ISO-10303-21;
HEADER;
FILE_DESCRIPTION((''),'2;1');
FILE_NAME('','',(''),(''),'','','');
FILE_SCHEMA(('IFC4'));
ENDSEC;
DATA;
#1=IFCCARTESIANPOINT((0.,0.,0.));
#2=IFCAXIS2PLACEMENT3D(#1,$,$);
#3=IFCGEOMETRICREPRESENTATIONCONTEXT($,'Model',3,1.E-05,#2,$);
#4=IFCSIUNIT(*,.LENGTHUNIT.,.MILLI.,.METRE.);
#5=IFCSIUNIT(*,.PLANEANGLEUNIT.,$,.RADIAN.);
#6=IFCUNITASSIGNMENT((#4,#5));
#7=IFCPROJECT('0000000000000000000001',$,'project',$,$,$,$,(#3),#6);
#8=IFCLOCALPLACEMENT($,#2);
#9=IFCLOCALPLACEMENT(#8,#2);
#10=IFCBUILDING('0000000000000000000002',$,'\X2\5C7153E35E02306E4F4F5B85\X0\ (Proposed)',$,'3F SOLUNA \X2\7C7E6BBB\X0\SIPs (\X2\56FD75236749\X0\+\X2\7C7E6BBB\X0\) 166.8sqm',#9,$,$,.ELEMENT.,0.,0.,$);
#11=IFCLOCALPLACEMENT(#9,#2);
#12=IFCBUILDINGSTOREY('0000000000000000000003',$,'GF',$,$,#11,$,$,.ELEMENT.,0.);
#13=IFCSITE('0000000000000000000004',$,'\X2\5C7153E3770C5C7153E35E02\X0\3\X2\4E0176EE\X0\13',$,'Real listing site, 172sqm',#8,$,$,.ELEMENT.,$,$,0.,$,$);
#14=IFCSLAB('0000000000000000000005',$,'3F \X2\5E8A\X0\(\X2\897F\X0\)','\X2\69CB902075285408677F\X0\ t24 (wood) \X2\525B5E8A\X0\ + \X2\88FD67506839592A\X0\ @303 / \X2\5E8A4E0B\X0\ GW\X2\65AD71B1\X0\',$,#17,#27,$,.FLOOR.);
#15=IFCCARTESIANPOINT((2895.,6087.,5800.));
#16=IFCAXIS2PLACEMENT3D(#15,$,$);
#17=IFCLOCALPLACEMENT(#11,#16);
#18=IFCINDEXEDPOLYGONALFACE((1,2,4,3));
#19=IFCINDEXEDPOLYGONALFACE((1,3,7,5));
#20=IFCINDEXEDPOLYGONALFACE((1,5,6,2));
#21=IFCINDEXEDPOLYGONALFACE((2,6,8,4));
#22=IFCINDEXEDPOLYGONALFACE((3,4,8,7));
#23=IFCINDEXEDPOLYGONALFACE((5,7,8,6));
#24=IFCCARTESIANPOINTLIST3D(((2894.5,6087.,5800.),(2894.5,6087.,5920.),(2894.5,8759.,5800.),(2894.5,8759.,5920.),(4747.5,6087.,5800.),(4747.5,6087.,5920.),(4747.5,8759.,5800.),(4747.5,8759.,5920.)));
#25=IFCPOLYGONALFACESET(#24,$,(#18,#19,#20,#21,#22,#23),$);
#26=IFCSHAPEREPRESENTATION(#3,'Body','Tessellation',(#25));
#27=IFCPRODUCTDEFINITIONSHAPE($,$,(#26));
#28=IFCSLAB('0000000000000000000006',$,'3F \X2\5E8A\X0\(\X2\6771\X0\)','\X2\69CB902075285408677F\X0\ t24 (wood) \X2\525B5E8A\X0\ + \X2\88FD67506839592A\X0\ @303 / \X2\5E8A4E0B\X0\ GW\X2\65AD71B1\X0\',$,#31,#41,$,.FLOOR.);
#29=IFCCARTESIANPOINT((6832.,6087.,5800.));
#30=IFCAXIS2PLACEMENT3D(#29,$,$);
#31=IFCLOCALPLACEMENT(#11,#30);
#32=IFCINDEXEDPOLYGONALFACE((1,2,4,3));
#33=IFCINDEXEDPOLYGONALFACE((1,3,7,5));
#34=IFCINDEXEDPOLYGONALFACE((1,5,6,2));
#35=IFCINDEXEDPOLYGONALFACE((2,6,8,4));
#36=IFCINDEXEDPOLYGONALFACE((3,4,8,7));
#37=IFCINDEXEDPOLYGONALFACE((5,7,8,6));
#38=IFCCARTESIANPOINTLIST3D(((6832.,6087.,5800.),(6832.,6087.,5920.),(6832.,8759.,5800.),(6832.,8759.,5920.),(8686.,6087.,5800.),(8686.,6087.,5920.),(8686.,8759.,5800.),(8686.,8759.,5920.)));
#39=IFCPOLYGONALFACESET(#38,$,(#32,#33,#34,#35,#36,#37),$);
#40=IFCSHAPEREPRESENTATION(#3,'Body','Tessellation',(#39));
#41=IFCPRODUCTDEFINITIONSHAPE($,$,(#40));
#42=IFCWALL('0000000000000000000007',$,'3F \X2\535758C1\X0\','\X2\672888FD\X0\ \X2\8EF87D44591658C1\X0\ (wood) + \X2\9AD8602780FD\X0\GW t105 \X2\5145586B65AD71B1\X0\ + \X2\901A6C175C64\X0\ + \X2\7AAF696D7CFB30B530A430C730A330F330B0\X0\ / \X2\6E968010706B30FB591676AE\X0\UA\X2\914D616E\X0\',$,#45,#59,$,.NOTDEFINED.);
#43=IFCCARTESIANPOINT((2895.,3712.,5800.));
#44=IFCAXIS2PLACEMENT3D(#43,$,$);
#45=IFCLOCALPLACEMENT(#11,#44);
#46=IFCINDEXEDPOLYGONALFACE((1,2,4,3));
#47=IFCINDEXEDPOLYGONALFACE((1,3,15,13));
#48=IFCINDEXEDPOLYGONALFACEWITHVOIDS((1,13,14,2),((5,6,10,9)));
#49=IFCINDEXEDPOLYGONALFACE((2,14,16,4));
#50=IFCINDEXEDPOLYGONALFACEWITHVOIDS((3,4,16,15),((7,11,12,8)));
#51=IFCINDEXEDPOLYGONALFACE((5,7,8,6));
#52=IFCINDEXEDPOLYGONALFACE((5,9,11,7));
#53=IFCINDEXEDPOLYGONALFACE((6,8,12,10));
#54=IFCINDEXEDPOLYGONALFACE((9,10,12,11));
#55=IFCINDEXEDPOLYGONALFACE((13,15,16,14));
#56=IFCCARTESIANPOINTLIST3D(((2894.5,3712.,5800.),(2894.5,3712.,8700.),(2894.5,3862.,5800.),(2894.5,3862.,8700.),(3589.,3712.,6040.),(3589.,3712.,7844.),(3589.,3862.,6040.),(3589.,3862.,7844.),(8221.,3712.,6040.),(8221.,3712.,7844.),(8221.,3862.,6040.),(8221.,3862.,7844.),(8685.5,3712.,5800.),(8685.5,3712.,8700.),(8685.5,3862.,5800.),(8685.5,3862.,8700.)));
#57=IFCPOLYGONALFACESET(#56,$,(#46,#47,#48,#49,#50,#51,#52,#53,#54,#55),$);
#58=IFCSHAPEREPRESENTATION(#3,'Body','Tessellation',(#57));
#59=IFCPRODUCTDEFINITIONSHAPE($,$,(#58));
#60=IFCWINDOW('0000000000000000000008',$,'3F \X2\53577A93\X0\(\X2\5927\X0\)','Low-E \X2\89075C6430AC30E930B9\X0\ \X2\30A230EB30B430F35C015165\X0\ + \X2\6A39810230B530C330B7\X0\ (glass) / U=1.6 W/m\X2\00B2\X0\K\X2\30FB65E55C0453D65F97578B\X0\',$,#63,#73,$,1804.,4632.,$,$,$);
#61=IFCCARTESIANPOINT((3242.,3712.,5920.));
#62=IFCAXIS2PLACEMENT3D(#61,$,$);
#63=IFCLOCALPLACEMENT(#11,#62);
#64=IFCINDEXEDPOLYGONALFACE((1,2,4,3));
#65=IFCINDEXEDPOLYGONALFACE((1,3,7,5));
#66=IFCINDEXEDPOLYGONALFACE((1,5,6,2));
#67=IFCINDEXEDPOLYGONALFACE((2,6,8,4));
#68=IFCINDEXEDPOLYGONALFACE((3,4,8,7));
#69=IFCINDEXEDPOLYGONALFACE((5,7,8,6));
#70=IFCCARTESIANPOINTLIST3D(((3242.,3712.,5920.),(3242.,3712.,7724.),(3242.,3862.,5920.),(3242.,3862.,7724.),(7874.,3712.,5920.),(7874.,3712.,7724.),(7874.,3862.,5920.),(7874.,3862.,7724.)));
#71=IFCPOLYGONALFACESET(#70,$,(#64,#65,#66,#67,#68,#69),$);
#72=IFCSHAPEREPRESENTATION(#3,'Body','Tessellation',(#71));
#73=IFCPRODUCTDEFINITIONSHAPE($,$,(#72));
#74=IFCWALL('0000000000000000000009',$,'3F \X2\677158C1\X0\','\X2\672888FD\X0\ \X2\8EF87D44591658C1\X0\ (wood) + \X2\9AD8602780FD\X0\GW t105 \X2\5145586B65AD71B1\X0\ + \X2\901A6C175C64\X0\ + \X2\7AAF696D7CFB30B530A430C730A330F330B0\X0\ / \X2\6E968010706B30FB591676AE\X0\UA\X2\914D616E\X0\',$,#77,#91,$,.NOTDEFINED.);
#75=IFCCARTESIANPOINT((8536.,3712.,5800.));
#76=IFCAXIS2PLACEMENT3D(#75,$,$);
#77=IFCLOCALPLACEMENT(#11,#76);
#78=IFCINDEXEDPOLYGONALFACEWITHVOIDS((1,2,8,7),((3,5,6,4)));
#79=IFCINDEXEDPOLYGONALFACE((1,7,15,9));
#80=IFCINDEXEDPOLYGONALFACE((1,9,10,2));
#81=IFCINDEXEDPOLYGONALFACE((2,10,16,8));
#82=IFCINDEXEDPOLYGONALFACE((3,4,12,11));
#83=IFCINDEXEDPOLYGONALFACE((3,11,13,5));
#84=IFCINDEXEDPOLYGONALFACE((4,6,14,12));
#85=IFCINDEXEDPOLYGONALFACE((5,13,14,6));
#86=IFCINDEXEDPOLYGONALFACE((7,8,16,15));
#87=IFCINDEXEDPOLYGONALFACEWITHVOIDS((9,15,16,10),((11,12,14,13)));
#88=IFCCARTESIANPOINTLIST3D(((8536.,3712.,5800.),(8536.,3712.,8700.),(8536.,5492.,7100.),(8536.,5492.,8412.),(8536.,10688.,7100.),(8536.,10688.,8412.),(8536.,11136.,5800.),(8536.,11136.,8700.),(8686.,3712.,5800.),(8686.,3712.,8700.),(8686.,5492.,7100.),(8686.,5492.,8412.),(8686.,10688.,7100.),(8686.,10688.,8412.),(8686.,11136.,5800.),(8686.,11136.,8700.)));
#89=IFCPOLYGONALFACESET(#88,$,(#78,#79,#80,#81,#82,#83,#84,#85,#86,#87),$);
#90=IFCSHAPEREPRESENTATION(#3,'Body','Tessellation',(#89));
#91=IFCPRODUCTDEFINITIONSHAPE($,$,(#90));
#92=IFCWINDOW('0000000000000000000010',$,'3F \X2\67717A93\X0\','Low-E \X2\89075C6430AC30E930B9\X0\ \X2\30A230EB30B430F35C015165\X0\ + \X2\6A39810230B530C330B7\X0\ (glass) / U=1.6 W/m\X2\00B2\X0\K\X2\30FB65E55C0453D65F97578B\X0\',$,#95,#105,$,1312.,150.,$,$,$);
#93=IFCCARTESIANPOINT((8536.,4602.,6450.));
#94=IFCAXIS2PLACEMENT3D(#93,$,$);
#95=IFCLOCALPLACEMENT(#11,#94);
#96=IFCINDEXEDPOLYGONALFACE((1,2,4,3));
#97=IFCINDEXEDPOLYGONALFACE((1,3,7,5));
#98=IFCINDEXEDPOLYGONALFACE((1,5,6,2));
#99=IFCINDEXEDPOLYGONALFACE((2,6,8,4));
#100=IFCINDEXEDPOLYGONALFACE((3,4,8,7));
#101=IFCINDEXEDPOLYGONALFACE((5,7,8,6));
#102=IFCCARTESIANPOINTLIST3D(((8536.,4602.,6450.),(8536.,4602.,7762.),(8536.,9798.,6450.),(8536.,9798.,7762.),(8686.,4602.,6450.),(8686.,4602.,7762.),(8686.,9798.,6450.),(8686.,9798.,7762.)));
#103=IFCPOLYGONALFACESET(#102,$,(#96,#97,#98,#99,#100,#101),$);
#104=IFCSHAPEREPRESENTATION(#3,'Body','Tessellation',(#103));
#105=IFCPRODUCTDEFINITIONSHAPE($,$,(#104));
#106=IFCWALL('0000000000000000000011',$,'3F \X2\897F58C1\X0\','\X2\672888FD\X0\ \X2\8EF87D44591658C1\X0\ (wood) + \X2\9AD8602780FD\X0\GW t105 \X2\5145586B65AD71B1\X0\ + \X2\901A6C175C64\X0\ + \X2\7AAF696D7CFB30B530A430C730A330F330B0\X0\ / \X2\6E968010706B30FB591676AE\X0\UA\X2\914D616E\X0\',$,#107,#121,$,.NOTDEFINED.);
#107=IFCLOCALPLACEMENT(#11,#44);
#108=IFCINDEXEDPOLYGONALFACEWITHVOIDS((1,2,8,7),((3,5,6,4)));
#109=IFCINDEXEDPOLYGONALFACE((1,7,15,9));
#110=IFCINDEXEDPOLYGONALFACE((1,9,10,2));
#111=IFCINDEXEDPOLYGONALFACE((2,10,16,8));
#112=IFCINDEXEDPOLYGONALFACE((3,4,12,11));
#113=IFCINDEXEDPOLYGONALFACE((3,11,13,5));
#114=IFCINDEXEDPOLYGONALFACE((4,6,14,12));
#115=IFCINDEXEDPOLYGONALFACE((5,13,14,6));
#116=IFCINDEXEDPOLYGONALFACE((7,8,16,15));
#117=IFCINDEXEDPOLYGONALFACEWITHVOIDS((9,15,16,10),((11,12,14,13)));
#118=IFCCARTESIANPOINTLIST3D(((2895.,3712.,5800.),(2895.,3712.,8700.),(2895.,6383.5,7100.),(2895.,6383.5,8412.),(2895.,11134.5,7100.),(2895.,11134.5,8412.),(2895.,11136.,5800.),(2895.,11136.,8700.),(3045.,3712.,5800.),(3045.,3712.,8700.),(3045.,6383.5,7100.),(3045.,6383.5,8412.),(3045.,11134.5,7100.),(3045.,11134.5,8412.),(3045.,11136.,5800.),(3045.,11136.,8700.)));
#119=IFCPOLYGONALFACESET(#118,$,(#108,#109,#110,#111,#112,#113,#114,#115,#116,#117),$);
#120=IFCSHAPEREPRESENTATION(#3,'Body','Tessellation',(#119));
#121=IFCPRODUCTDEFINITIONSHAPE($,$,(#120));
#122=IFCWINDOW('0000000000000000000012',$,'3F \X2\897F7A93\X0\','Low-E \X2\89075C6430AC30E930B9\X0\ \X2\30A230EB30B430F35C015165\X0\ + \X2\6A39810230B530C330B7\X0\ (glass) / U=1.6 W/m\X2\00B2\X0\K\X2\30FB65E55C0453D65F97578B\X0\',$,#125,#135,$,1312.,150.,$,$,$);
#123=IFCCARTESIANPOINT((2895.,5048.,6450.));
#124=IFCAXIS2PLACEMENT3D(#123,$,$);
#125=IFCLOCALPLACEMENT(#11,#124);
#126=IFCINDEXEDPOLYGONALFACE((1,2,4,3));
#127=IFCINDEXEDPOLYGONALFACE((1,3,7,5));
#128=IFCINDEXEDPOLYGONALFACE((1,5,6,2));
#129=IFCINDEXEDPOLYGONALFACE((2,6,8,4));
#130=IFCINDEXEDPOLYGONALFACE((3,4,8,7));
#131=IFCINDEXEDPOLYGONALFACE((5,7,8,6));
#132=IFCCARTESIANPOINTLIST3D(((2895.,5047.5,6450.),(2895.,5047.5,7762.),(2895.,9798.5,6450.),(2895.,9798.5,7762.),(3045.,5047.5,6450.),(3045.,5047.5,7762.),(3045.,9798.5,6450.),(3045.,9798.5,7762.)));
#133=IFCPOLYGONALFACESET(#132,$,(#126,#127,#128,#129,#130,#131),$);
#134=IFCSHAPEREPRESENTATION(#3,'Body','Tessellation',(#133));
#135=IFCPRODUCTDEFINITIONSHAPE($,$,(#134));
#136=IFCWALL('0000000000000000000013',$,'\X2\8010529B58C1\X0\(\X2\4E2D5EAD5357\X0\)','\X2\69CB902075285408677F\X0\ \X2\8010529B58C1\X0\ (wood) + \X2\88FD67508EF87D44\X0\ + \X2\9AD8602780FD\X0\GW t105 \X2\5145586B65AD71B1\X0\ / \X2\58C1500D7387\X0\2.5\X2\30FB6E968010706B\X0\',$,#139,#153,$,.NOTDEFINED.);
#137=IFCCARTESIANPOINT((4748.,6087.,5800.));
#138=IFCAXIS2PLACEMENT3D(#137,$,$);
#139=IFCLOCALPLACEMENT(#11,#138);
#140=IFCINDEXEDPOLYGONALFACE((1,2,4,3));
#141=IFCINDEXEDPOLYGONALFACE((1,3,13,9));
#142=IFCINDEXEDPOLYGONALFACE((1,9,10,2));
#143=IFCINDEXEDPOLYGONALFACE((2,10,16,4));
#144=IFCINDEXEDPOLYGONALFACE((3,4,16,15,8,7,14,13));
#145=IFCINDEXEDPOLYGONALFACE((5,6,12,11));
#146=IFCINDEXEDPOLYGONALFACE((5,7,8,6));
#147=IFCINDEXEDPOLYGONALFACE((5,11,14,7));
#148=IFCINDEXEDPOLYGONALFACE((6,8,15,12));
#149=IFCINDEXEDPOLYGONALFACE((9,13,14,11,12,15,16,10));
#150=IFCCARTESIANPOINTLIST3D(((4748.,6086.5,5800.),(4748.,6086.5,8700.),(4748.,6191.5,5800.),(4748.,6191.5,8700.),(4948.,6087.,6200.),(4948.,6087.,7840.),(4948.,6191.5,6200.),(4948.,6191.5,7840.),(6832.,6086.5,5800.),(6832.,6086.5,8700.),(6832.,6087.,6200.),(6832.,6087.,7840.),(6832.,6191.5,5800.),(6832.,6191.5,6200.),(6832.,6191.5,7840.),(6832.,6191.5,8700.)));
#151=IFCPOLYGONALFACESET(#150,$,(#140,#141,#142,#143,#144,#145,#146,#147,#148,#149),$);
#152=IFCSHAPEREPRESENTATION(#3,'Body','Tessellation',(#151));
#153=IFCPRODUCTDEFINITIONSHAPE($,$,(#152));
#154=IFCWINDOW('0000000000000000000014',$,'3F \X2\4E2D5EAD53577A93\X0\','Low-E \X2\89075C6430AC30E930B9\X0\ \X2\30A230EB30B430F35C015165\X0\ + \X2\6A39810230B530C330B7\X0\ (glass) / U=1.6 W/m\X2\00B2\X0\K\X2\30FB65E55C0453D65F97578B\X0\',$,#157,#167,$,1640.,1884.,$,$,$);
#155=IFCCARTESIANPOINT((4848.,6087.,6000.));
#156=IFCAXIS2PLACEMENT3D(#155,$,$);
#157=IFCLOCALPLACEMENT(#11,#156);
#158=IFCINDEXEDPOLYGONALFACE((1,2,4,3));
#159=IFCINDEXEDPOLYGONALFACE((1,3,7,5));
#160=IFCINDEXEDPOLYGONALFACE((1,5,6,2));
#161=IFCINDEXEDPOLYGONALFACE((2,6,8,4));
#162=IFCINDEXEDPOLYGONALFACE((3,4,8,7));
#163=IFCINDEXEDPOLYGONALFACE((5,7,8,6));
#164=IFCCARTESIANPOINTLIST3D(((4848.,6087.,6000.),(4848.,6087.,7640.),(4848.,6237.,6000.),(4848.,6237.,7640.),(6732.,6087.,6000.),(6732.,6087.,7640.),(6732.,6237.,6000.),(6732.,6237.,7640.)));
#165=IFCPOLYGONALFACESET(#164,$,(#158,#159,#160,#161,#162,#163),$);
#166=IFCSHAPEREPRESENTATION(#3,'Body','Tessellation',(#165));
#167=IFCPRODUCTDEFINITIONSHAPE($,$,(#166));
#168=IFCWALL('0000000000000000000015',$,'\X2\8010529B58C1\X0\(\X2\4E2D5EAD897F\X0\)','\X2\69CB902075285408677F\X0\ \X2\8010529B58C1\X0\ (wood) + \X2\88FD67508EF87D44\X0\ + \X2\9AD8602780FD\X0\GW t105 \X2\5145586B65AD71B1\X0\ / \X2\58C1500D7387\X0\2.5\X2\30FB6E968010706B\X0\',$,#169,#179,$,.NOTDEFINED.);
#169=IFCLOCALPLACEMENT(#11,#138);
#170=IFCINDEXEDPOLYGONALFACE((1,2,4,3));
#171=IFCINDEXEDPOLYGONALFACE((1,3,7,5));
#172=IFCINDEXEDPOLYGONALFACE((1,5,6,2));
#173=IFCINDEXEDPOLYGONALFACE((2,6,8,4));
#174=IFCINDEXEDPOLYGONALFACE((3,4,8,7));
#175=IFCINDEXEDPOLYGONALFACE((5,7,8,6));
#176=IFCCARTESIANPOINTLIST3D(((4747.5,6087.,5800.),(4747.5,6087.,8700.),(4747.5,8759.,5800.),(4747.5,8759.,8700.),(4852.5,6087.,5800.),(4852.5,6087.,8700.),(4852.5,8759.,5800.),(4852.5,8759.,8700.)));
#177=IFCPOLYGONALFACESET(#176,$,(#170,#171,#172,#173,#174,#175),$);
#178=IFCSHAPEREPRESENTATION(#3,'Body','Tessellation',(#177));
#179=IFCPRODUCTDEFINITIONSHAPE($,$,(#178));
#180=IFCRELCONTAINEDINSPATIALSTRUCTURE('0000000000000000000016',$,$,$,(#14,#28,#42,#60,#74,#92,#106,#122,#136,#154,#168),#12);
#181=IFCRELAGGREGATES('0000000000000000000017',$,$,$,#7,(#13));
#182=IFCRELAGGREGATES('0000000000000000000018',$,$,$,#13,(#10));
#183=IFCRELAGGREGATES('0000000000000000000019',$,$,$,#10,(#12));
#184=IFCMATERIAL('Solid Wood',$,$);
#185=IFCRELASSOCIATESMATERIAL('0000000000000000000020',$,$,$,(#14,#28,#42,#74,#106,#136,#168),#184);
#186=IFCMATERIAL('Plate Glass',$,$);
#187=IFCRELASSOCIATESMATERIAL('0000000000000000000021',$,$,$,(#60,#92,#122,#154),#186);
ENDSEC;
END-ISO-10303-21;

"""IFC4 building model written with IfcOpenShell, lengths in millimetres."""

from ifc_helpers import new_model, si_unit, frame, frame_2d, origin, place, context, project, spatial, rectangle, extrude, material, element, fill, save


model = new_model("IFC4")

# Units and contexts
model_context = context("Model", 3, precision=1e-05, world=origin())
ifc_project = project(units=[si_unit("LENGTHUNIT", "METRE", prefix="MILLI"), si_unit("PLANEANGLEUNIT", "RADIAN")], contexts=[model_context])

# Site, building, storey
site_placement = place(None, origin())
site = spatial("IfcSite", under=ifc_project, at=site_placement, Name="山口県山口市3丁目13", ObjectType="Real listing site, 172sqm", CompositionType="ELEMENT", RefElevation=0.0)
building_placement = place(site_placement, origin())
building = spatial("IfcBuilding", under=site, at=building_placement, Name="山口市の住宅 (Proposed)", ObjectType="3F SOLUNA 籾殻SIPs (国産杉+籾殻) 166.8sqm", CompositionType="ELEMENT", ElevationOfRefHeight=0.0, ElevationOfTerrain=0.0)
storey_placement = place(building_placement, origin())
storey = spatial("IfcBuildingStorey", under=building, at=storey_placement, Name="GF", CompositionType="ELEMENT", Elevation=0.0)

# Slabs
ifc_material_1 = material(Name="Solid Wood")
slab_1_placement = place(storey_placement, frame((2895.0, 6087.0, 5800.0)))
element("IfcSlab", 1, at=slab_1_placement, inside=storey, material=ifc_material_1, Name="3F 床(西)", Description="構造用合板 t24 (wood) 剛床 + 製材根太 @303 / 床下 GW断熱", PredefinedType="FLOOR", context=model_context, shape_type="SweptSolid", body=[
    extrude(rectangle(XDim=1853.0, YDim=2672.0, at=frame_2d((926.0, 1336.0))), frame((2895.0, 6087.0, 5800.0)), (0.0, 0.0, 1.0), 120.0),
])
slab_2_placement = place(storey_placement, frame((6832.0, 6087.0, 5800.0)))
element("IfcSlab", 2, at=slab_2_placement, inside=storey, material=ifc_material_1, Name="3F 床(東)", Description="構造用合板 t24 (wood) 剛床 + 製材根太 @303 / 床下 GW断熱", PredefinedType="FLOOR", context=model_context, shape_type="SweptSolid", body=[
    extrude(rectangle(XDim=1854.0, YDim=2672.0, at=frame_2d((927.0, 1336.0))), frame((6832.0, 6087.0, 5800.0)), (0.0, 0.0, 1.0), 120.0),
])

# Walls, openings, windows
wall_1_placement = place(storey_placement, frame((2895.0, 3712.0, 5800.0)))
wall_1 = element("IfcWall", 3, at=wall_1_placement, inside=storey, material=ifc_material_1, Name="3F 南壁", Description="木製 軸組外壁 (wood) + 高性能GW t105 充填断熱 + 通気層 + 窯業系サイディング / 準耐火・外皮UA配慮", PredefinedType="NOTDEFINED", context=model_context, shape_type="SweptSolid", body=[
    extrude(rectangle(XDim=5791.0, YDim=150.0, at=frame_2d((2895.0, 75.0))), frame((2895.0, 3712.0, 5800.0)), (0.0, 0.0, 1.0), 2900.0),
])
opening_1_placement = place(storey_placement, frame((3242.0, 3712.0, 5920.0)))
opening_1 = element("IfcOpeningElement", 4, at=opening_1_placement, cuts=wall_1, PredefinedType="NOTDEFINED", context=model_context, shape_type="SweptSolid", body=[
    extrude(rectangle(XDim=4632.0, YDim=150.0, at=frame_2d((2316.0, 75.0))), frame((3242.0, 3712.0, 5920.0)), (0.0, 0.0, 1.0), 1804.0),
])
ifc_material_2 = material(Name="Plate Glass")
window_1_placement = place(storey_placement, frame((3242.0, 3712.0, 5920.0)))
window_1 = element("IfcWindow", 5, at=window_1_placement, inside=storey, material=ifc_material_2, Name="3F 南窓(大)", Description="Low-E 複層ガラス アルゴン封入 + 樹脂サッシ (glass) / U=1.6 W/m²K・日射取得型", OverallHeight=1804.0, OverallWidth=4632.0, context=model_context, shape_type="SweptSolid", body=[
    extrude(rectangle(XDim=4632.0, YDim=150.0, at=frame_2d((2316.0, 75.0))), frame((3242.0, 3712.0, 5920.0)), (0.0, 0.0, 1.0), 1804.0),
])
fill(opening_1, window_1)
wall_2_placement = place(storey_placement, frame((8536.0, 3712.0, 5800.0)))
wall_2 = element("IfcWall", 6, at=wall_2_placement, inside=storey, material=ifc_material_1, Name="3F 東壁", Description="木製 軸組外壁 (wood) + 高性能GW t105 充填断熱 + 通気層 + 窯業系サイディング / 準耐火・外皮UA配慮", PredefinedType="NOTDEFINED", context=model_context, shape_type="SweptSolid", body=[
    extrude(rectangle(XDim=150.0, YDim=7424.0, at=frame_2d((75.0, 3712.0))), frame((8536.0, 3712.0, 5800.0)), (0.0, 0.0, 1.0), 2900.0),
])
opening_2_placement = place(storey_placement, frame((8536.0, 4602.0, 6450.0)))
opening_2 = element("IfcOpeningElement", 7, at=opening_2_placement, cuts=wall_2, PredefinedType="NOTDEFINED", context=model_context, shape_type="SweptSolid", body=[
    extrude(rectangle(XDim=150.0, YDim=5196.0, at=frame_2d((75.0, 2598.0))), frame((8536.0, 4602.0, 6450.0)), (0.0, 0.0, 1.0), 1312.0),
])
window_2_placement = place(storey_placement, frame((8536.0, 4602.0, 6450.0)))
window_2 = element("IfcWindow", 8, at=window_2_placement, inside=storey, material=ifc_material_2, Name="3F 東窓", Description="Low-E 複層ガラス アルゴン封入 + 樹脂サッシ (glass) / U=1.6 W/m²K・日射取得型", OverallHeight=1312.0, OverallWidth=150.0, context=model_context, shape_type="SweptSolid", body=[
    extrude(rectangle(XDim=150.0, YDim=5196.0, at=frame_2d((75.0, 2598.0))), frame((8536.0, 4602.0, 6450.0)), (0.0, 0.0, 1.0), 1312.0),
])
fill(opening_2, window_2)
wall_3_placement = place(storey_placement, frame((2895.0, 3712.0, 5800.0)))
wall_3 = element("IfcWall", 9, at=wall_3_placement, inside=storey, material=ifc_material_1, Name="3F 西壁", Description="木製 軸組外壁 (wood) + 高性能GW t105 充填断熱 + 通気層 + 窯業系サイディング / 準耐火・外皮UA配慮", PredefinedType="NOTDEFINED", context=model_context, shape_type="SweptSolid", body=[
    extrude(rectangle(XDim=150.0, YDim=7424.0, at=frame_2d((75.0, 3712.0))), frame((2895.0, 3712.0, 5800.0)), (0.0, 0.0, 1.0), 2900.0),
])
opening_3_placement = place(storey_placement, frame((2895.0, 5048.0, 6450.0)))
opening_3 = element("IfcOpeningElement", 10, at=opening_3_placement, cuts=wall_3, PredefinedType="NOTDEFINED", context=model_context, shape_type="SweptSolid", body=[
    extrude(rectangle(XDim=150.0, YDim=4751.0, at=frame_2d((75.0, 2375.0))), frame((2895.0, 5048.0, 6450.0)), (0.0, 0.0, 1.0), 1312.0),
])
window_3_placement = place(storey_placement, frame((2895.0, 5048.0, 6450.0)))
window_3 = element("IfcWindow", 11, at=window_3_placement, inside=storey, material=ifc_material_2, Name="3F 西窓", Description="Low-E 複層ガラス アルゴン封入 + 樹脂サッシ (glass) / U=1.6 W/m²K・日射取得型", OverallHeight=1312.0, OverallWidth=150.0, context=model_context, shape_type="SweptSolid", body=[
    extrude(rectangle(XDim=150.0, YDim=4751.0, at=frame_2d((75.0, 2375.0))), frame((2895.0, 5048.0, 6450.0)), (0.0, 0.0, 1.0), 1312.0),
])
fill(opening_3, window_3)
wall_4_placement = place(storey_placement, frame((4748.0, 6087.0, 5800.0)))
wall_4 = element("IfcWall", 12, at=wall_4_placement, inside=storey, material=ifc_material_1, Name="耐力壁(中庭南)", Description="構造用合板 耐力壁 (wood) + 製材軸組 + 高性能GW t105 充填断熱 / 壁倍率2.5・準耐火", PredefinedType="NOTDEFINED", context=model_context, shape_type="SweptSolid", body=[
    extrude(rectangle(XDim=2084.0, YDim=105.0, at=frame_2d((1042.0, 52.0))), frame((4748.0, 6087.0, 5800.0)), (0.0, 0.0, 1.0), 2900.0),
])
opening_4_placement = place(storey_placement, frame((4848.0, 6087.0, 6000.0)))
opening_4 = element("IfcOpeningElement", 13, at=opening_4_placement, cuts=wall_4, PredefinedType="NOTDEFINED", context=model_context, shape_type="SweptSolid", body=[
    extrude(rectangle(XDim=1884.0, YDim=150.0, at=frame_2d((942.0, 75.0))), frame((4848.0, 6087.0, 6000.0)), (0.0, 0.0, 1.0), 1640.0),
])
window_4_placement = place(storey_placement, frame((4848.0, 6087.0, 6000.0)))
window_4 = element("IfcWindow", 14, at=window_4_placement, inside=storey, material=ifc_material_2, Name="3F 中庭南窓", Description="Low-E 複層ガラス アルゴン封入 + 樹脂サッシ (glass) / U=1.6 W/m²K・日射取得型", OverallHeight=1640.0, OverallWidth=1884.0, context=model_context, shape_type="SweptSolid", body=[
    extrude(rectangle(XDim=1884.0, YDim=150.0, at=frame_2d((942.0, 75.0))), frame((4848.0, 6087.0, 6000.0)), (0.0, 0.0, 1.0), 1640.0),
])
fill(opening_4, window_4)

# Wall
wall_5_placement = place(storey_placement, frame((4748.0, 6087.0, 5800.0)))
element("IfcWall", 15, at=wall_5_placement, inside=storey, material=ifc_material_1, Name="耐力壁(中庭西)", Description="構造用合板 耐力壁 (wood) + 製材軸組 + 高性能GW t105 充填断熱 / 壁倍率2.5・準耐火", PredefinedType="NOTDEFINED", context=model_context, shape_type="SweptSolid", body=[
    extrude(rectangle(XDim=105.0, YDim=2672.0, at=frame_2d((52.0, 1336.0))), frame((4748.0, 6087.0, 5800.0)), (0.0, 0.0, 1.0), 2900.0),
])

save(model, "model.ifc")
